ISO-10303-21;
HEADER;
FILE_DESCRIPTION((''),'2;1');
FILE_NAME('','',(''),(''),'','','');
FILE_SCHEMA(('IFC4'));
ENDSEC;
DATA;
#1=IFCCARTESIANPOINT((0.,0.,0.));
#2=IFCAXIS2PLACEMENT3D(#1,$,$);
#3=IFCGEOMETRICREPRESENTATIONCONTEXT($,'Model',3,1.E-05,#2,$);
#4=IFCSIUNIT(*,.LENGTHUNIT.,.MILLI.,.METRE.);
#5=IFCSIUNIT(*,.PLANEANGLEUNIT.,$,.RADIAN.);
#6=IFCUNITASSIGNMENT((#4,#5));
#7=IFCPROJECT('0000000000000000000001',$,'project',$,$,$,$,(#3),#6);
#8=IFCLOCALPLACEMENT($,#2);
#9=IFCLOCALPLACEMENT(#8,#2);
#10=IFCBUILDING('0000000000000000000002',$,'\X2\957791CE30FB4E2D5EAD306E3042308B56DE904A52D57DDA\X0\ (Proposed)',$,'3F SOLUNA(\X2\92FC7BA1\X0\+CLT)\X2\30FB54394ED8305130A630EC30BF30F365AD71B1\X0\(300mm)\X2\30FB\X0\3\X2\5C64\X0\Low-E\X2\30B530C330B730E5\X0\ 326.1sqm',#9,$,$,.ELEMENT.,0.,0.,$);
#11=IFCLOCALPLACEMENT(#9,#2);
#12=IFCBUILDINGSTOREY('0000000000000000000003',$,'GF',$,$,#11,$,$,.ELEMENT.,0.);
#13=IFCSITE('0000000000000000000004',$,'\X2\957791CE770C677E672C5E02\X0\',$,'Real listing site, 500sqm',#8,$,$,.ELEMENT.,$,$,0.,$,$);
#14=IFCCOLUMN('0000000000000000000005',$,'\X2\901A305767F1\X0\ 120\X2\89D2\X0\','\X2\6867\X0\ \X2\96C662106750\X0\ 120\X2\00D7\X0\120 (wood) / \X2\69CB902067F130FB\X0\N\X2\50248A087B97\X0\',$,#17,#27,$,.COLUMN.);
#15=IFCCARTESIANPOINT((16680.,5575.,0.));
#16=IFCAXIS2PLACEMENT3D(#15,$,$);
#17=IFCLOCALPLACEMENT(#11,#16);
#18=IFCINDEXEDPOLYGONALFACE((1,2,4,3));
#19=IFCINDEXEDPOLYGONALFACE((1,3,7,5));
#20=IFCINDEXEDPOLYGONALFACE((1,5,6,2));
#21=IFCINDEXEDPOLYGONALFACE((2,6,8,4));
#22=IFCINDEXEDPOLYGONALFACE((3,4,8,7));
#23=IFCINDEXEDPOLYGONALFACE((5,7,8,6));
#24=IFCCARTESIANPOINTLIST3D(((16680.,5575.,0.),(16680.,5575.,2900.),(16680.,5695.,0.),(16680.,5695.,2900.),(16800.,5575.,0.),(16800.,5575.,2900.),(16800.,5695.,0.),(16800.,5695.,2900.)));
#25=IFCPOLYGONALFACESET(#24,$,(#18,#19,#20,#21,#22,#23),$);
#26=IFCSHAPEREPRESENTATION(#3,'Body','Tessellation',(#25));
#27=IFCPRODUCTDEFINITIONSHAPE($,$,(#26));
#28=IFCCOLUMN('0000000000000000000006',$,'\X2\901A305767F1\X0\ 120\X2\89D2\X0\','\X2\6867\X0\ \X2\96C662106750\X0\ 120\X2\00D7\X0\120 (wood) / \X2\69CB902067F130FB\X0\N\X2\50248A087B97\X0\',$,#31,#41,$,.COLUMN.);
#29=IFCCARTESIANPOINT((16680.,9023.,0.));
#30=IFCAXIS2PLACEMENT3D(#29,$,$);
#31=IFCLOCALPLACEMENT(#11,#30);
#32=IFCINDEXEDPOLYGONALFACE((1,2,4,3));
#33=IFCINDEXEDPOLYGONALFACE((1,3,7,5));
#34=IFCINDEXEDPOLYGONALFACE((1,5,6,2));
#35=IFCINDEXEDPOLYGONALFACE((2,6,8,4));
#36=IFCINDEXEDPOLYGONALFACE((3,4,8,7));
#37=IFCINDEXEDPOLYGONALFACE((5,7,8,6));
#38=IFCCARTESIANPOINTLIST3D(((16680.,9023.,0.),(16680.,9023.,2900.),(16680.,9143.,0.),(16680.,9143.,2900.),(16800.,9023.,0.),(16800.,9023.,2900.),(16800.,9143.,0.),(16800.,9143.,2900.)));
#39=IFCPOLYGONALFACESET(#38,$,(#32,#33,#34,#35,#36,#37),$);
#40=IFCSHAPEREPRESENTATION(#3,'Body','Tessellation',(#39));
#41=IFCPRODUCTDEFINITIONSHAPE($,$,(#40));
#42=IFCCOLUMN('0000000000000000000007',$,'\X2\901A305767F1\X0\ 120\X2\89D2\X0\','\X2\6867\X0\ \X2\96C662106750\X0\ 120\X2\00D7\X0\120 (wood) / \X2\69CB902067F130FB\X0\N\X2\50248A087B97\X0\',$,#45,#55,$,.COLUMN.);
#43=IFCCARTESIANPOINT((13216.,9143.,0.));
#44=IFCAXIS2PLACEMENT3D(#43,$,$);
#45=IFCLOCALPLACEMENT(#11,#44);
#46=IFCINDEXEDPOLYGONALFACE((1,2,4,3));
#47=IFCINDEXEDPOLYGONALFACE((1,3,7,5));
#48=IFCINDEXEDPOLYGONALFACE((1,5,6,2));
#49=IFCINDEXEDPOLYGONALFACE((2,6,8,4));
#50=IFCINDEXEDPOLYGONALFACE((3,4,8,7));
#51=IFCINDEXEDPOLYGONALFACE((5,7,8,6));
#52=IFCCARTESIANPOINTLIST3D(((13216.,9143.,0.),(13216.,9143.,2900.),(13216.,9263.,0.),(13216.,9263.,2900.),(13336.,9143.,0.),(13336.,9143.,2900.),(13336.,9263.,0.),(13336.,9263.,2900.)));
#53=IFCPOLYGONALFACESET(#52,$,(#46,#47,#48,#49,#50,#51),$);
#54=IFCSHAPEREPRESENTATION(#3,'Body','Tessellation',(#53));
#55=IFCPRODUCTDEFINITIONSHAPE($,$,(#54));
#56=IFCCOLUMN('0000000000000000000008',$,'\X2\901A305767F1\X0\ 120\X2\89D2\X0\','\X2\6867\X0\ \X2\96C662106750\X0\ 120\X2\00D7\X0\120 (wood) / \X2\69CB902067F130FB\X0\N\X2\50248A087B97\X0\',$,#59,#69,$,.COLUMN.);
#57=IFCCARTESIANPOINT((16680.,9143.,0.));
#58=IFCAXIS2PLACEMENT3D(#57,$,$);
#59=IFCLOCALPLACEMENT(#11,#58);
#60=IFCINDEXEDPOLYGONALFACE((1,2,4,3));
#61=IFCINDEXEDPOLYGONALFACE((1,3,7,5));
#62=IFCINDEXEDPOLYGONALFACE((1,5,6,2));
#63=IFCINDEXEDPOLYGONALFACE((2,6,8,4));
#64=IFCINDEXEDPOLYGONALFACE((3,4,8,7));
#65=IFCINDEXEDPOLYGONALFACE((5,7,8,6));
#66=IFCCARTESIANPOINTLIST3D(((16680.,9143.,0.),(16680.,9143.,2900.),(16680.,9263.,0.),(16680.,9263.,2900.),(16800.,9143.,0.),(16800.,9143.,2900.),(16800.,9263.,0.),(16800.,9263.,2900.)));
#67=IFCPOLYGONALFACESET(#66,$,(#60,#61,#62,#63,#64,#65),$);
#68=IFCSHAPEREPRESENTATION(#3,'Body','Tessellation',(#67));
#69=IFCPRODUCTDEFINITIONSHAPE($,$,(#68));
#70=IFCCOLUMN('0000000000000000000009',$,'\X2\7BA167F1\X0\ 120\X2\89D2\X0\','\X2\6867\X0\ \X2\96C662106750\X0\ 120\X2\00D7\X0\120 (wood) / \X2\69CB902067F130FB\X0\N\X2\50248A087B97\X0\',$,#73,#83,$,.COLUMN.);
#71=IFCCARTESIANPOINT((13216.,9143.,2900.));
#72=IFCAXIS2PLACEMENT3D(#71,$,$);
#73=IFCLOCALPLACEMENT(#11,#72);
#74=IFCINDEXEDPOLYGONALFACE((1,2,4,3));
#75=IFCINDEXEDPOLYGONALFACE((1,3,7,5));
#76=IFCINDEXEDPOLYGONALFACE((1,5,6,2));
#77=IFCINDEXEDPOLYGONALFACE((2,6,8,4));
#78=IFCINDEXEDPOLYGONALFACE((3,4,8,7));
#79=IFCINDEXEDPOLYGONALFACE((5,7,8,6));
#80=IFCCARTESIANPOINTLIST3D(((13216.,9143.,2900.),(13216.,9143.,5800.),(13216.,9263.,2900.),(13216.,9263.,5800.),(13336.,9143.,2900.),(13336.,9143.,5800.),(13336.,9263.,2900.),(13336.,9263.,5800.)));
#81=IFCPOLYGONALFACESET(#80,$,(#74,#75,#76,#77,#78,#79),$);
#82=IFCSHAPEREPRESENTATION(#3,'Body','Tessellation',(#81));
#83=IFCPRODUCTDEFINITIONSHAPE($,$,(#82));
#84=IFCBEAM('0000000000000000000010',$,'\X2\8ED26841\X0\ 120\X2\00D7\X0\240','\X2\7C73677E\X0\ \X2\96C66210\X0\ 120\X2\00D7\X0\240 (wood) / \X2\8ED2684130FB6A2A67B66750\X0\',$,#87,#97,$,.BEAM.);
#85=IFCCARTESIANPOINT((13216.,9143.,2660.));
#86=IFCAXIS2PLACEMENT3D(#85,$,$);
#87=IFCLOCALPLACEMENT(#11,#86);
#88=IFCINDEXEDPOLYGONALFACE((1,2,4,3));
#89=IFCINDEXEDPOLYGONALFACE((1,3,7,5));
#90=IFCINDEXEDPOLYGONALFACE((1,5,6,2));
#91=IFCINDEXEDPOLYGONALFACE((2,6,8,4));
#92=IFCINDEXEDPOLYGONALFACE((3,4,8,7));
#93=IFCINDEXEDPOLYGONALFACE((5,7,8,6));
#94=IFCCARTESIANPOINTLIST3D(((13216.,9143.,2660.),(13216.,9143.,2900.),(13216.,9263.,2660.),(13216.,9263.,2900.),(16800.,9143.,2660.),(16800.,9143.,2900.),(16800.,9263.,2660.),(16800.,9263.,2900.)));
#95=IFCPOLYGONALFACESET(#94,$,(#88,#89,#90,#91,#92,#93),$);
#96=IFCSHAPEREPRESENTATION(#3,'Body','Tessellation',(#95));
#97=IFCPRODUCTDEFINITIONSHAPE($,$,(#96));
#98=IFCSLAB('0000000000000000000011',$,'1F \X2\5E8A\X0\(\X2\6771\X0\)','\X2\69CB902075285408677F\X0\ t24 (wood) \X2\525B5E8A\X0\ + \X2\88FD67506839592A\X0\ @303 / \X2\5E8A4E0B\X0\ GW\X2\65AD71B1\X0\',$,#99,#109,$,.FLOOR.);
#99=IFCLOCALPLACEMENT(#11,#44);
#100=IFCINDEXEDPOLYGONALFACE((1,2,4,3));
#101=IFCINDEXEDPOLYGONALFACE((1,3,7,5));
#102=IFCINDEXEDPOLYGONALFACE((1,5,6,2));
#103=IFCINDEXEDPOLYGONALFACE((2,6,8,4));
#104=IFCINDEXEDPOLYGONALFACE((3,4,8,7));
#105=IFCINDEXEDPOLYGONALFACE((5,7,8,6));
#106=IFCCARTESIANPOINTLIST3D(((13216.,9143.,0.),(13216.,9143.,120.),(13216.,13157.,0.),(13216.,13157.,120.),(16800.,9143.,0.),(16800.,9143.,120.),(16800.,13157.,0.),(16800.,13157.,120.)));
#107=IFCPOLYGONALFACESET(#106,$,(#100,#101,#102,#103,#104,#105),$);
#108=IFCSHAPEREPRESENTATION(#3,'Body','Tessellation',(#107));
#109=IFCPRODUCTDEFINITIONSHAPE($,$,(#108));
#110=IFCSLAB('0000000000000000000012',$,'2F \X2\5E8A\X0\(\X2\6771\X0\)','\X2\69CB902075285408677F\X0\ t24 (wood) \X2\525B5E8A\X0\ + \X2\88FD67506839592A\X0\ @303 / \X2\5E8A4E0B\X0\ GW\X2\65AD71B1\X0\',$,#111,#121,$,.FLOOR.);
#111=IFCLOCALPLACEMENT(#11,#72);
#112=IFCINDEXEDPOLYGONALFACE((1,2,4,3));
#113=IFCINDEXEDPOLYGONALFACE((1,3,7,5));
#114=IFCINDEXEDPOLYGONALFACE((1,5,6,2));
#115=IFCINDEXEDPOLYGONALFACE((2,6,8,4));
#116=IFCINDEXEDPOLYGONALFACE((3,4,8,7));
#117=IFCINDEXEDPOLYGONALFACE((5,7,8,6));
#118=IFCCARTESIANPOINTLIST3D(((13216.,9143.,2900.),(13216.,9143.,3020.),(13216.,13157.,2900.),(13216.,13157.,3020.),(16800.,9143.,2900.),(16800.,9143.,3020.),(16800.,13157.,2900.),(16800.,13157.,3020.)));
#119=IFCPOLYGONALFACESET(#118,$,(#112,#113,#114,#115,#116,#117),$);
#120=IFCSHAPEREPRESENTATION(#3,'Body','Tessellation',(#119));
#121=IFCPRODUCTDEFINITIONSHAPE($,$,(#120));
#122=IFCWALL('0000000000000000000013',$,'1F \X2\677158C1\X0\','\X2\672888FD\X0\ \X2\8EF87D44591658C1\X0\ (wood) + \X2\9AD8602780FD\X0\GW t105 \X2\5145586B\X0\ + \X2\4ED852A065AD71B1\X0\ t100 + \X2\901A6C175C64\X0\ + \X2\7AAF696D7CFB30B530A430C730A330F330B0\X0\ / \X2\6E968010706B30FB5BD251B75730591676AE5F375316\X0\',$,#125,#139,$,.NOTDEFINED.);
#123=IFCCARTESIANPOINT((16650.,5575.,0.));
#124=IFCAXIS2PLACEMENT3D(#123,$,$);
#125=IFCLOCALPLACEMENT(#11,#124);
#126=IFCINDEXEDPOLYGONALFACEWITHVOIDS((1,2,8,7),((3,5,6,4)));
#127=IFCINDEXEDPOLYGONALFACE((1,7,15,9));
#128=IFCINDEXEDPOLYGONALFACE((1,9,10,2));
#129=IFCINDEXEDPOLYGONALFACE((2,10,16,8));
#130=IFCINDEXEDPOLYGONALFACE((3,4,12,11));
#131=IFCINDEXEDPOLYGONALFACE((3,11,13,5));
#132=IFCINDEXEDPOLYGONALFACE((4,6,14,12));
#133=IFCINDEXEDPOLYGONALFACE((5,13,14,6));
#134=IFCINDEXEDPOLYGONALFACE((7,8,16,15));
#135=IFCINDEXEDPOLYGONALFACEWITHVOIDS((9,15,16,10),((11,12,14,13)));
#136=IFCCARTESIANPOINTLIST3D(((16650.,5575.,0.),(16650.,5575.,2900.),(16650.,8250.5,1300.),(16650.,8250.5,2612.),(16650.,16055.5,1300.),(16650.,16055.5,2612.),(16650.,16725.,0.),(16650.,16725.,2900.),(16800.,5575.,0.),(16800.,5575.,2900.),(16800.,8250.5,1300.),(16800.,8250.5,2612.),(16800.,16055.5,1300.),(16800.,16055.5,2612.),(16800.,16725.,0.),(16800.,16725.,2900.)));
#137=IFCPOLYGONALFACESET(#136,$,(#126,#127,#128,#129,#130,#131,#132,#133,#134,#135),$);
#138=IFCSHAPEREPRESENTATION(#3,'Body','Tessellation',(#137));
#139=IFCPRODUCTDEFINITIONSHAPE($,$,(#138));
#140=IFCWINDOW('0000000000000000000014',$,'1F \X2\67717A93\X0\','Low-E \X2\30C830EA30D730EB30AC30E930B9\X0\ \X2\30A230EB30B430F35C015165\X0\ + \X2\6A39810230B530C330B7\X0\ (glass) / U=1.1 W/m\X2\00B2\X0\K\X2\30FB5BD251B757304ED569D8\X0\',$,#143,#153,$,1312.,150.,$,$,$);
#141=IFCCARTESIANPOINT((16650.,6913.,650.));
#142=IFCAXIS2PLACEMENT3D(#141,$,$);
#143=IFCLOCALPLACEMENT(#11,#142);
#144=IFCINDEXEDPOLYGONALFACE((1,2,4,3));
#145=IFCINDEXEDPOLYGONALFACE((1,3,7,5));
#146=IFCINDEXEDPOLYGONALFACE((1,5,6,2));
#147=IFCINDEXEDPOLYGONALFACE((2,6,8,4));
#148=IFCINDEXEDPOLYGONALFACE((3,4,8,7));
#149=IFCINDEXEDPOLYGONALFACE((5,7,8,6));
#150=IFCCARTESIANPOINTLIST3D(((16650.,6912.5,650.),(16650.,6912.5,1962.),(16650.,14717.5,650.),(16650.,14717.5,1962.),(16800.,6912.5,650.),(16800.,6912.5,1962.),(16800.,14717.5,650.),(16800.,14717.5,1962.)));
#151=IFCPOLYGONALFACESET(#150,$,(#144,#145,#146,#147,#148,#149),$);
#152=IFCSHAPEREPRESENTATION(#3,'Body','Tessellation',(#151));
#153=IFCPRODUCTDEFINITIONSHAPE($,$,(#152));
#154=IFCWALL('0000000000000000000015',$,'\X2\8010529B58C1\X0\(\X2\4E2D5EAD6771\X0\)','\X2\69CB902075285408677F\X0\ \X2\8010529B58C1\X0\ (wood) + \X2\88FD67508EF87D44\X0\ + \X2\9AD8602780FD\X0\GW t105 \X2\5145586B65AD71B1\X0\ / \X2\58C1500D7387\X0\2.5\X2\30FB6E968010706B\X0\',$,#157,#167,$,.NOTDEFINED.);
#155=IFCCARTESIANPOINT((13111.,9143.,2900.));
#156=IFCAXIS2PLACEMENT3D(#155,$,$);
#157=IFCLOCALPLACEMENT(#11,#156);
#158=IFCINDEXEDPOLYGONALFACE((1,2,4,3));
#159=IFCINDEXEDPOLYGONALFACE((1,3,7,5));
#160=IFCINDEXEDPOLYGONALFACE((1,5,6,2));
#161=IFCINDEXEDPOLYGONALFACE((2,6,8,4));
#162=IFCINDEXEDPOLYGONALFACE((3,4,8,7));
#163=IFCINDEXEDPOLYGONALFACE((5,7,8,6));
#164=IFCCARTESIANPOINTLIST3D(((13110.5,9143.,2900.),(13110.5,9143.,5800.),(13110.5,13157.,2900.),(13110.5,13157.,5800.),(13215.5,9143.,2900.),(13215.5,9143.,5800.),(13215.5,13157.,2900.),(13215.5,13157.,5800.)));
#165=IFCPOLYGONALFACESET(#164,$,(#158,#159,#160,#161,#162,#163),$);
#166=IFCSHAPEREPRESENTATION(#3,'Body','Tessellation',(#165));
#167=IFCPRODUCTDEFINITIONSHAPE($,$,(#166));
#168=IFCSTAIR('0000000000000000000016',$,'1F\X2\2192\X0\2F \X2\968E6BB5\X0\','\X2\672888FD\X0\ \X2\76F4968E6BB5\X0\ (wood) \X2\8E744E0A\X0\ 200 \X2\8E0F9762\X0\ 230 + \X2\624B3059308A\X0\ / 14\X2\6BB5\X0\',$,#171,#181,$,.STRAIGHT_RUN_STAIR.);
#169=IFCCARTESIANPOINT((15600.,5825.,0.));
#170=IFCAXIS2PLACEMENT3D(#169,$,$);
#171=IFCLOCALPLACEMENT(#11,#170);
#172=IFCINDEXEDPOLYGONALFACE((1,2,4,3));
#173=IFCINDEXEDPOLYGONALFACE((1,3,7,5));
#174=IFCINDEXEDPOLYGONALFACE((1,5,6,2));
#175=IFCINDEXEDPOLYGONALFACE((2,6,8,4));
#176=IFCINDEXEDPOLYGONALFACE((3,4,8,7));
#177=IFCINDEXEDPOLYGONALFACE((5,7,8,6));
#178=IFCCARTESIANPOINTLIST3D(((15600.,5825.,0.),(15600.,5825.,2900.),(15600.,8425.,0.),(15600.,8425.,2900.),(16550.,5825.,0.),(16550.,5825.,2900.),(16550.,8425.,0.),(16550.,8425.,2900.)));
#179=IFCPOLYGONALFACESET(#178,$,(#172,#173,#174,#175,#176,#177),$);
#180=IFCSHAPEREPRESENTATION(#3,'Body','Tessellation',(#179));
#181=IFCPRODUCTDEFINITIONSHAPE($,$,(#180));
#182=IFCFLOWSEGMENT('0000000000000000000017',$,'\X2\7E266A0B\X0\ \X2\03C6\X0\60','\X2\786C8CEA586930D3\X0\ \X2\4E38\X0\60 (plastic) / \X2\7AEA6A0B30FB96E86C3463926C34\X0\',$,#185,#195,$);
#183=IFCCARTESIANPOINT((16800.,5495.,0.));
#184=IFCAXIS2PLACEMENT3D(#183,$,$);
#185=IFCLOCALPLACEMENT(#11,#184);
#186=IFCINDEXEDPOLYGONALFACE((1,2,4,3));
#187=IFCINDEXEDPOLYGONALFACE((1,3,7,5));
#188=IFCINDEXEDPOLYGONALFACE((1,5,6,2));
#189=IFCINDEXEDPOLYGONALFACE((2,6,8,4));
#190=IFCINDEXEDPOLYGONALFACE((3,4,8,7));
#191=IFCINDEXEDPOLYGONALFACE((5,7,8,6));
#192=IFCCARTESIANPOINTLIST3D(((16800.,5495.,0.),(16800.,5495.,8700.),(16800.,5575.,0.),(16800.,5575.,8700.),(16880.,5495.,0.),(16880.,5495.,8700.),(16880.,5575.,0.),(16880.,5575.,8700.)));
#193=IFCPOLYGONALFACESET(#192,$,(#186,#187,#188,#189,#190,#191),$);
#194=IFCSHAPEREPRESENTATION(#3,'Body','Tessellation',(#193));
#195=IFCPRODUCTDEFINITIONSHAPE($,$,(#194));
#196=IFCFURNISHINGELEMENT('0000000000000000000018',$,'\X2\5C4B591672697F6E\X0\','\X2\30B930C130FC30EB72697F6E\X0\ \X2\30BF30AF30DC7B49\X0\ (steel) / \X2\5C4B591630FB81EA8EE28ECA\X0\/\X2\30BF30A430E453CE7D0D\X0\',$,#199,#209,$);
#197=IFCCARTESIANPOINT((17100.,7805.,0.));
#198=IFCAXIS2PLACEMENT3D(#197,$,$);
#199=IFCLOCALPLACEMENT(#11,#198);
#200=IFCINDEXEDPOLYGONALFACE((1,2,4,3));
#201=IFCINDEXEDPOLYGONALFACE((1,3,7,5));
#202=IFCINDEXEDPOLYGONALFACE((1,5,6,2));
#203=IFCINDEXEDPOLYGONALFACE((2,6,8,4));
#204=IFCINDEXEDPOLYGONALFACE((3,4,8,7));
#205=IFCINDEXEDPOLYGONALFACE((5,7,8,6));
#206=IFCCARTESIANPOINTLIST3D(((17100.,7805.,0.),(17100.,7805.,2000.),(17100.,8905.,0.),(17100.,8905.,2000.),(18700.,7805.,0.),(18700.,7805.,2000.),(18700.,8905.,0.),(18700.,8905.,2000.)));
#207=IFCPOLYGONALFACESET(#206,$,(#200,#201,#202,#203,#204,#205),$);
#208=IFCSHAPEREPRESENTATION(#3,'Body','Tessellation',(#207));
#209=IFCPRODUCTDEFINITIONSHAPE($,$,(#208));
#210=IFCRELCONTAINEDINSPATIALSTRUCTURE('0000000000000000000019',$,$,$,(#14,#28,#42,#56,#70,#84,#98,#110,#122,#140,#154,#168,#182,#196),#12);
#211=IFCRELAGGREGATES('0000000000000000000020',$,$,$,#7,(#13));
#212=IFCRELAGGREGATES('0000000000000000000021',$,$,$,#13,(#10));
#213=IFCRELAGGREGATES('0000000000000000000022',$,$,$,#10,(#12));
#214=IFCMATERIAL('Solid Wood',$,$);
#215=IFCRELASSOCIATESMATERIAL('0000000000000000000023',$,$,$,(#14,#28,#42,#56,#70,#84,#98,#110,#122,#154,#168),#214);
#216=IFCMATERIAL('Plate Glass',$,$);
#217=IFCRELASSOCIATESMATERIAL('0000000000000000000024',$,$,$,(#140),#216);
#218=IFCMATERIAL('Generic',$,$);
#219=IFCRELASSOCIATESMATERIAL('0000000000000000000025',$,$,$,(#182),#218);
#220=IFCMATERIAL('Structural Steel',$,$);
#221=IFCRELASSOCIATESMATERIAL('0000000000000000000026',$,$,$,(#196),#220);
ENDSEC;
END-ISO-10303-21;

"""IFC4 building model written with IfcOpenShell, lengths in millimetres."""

from ifc_helpers import new_model, si_unit, frame, frame_2d, origin, place, context, project, spatial, rectangle, extrude, material, element, fill, save


model = new_model("IFC4")

# Units and contexts
model_context = context("Model", 3, precision=1e-05, world=origin())
ifc_project = project(units=[si_unit("LENGTHUNIT", "METRE", prefix="MILLI"), si_unit("PLANEANGLEUNIT", "RADIAN")], contexts=[model_context])

# Site, building, storey
site_placement = place(None, origin())
site = spatial("IfcSite", under=ifc_project, at=site_placement, Name="長野県松本市", ObjectType="Real listing site, 500sqm", CompositionType="ELEMENT", RefElevation=0.0)
building_placement = place(site_placement, origin())
building = spatial("IfcBuilding", under=site, at=building_placement, Name="長野・中庭のある回遊動線 (Proposed)", ObjectType="3F SOLUNA(鋼管+CLT)・吹付けウレタン断熱(300mm)・3層Low-Eサッシュ 326.1sqm", CompositionType="ELEMENT", ElevationOfRefHeight=0.0, ElevationOfTerrain=0.0)
storey_placement = place(building_placement, origin())
storey = spatial("IfcBuildingStorey", under=building, at=storey_placement, Name="GF", CompositionType="ELEMENT", Elevation=0.0)

# Columns
ifc_material_1 = material(Name="Solid Wood")
column_1_placement = place(storey_placement, frame((16680.0, 5575.0, 0.0)))
element("IfcColumn", 1, at=column_1_placement, inside=storey, material=ifc_material_1, Name="通し柱 120角", Description="桧 集成材 120×120 (wood) / 構造柱・N値計算", PredefinedType="COLUMN", context=model_context, shape_type="SweptSolid", body=[
    extrude(rectangle(XDim=120.0, YDim=120.0, at=frame_2d((60.0, 60.0))), frame((16680.0, 5575.0, 0.0)), (0.0, 0.0, 1.0), 2900.0),
])
column_2_placement = place(storey_placement, frame((16680.0, 9023.0, 0.0)))
element("IfcColumn", 2, at=column_2_placement, inside=storey, material=ifc_material_1, Name="通し柱 120角", Description="桧 集成材 120×120 (wood) / 構造柱・N値計算", PredefinedType="COLUMN", context=model_context, shape_type="SweptSolid", body=[
    extrude(rectangle(XDim=120.0, YDim=120.0, at=frame_2d((60.0, 60.0))), frame((16680.0, 9023.0, 0.0)), (0.0, 0.0, 1.0), 2900.0),
])
column_3_placement = place(storey_placement, frame((13216.0, 9143.0, 0.0)))
element("IfcColumn", 3, at=column_3_placement, inside=storey, material=ifc_material_1, Name="通し柱 120角", Description="桧 集成材 120×120 (wood) / 構造柱・N値計算", PredefinedType="COLUMN", context=model_context, shape_type="SweptSolid", body=[
    extrude(rectangle(XDim=120.0, YDim=120.0, at=frame_2d((60.0, 60.0))), frame((13216.0, 9143.0, 0.0)), (0.0, 0.0, 1.0), 2900.0),
])
column_4_placement = place(storey_placement, frame((16680.0, 9143.0, 0.0)))
element("IfcColumn", 4, at=column_4_placement, inside=storey, material=ifc_material_1, Name="通し柱 120角", Description="桧 集成材 120×120 (wood) / 構造柱・N値計算", PredefinedType="COLUMN", context=model_context, shape_type="SweptSolid", body=[
    extrude(rectangle(XDim=120.0, YDim=120.0, at=frame_2d((60.0, 60.0))), frame((16680.0, 9143.0, 0.0)), (0.0, 0.0, 1.0), 2900.0),
])
column_5_placement = place(storey_placement, frame((13216.0, 9143.0, 2900.0)))
element("IfcColumn", 5, at=column_5_placement, inside=storey, material=ifc_material_1, Name="管柱 120角", Description="桧 集成材 120×120 (wood) / 構造柱・N値計算", PredefinedType="COLUMN", context=model_context, shape_type="SweptSolid", body=[
    extrude(rectangle(XDim=120.0, YDim=120.0, at=frame_2d((60.0, 60.0))), frame((13216.0, 9143.0, 2900.0)), (0.0, 0.0, 1.0), 2900.0),
])

# Beam
beam_1_placement = place(storey_placement, frame((13216.0, 9143.0, 2660.0)))
element("IfcBeam", 6, at=beam_1_placement, inside=storey, material=ifc_material_1, Name="軒桁 120×240", Description="米松 集成 120×240 (wood) / 軒桁・横架材", PredefinedType="BEAM", context=model_context, shape_type="SweptSolid", body=[
    extrude(rectangle(XDim=3584.0, YDim=120.0, at=frame_2d((1792.0, 60.0))), frame((13216.0, 9143.0, 2660.0)), (0.0, 0.0, 1.0), 240.0),
])

# Slabs
slab_1_placement = place(storey_placement, frame((13216.0, 9143.0, 0.0)))
element("IfcSlab", 7, at=slab_1_placement, inside=storey, material=ifc_material_1, Name="1F 床(東)", Description="構造用合板 t24 (wood) 剛床 + 製材根太 @303 / 床下 GW断熱", PredefinedType="FLOOR", context=model_context, shape_type="SweptSolid", body=[
    extrude(rectangle(XDim=3584.0, YDim=4014.0, at=frame_2d((1792.0, 2007.0))), frame((13216.0, 9143.0, 0.0)), (0.0, 0.0, 1.0), 120.0),
])
slab_2_placement = place(storey_placement, frame((13216.0, 9143.0, 2900.0)))
element("IfcSlab", 8, at=slab_2_placement, inside=storey, material=ifc_material_1, Name="2F 床(東)", Description="構造用合板 t24 (wood) 剛床 + 製材根太 @303 / 床下 GW断熱", PredefinedType="FLOOR", context=model_context, shape_type="SweptSolid", body=[
    extrude(rectangle(XDim=3584.0, YDim=4014.0, at=frame_2d((1792.0, 2007.0))), frame((13216.0, 9143.0, 2900.0)), (0.0, 0.0, 1.0), 120.0),
])

# Wall, opening, window
wall_1_placement = place(storey_placement, frame((16650.0, 5575.0, 0.0)))
wall_1 = element("IfcWall", 9, at=wall_1_placement, inside=storey, material=ifc_material_1, Name="1F 東壁", Description="木製 軸組外壁 (wood) + 高性能GW t105 充填 + 付加断熱 t100 + 通気層 + 窯業系サイディング / 準耐火・寒冷地外皮強化", PredefinedType="NOTDEFINED", context=model_context, shape_type="SweptSolid", body=[
    extrude(rectangle(XDim=150.0, YDim=11150.0, at=frame_2d((75.0, 5575.0))), frame((16650.0, 5575.0, 0.0)), (0.0, 0.0, 1.0), 2900.0),
])
opening_placement = place(storey_placement, frame((16650.0, 6913.0, 650.0)))
opening = element("IfcOpeningElement", 10, at=opening_placement, cuts=wall_1, PredefinedType="NOTDEFINED", context=model_context, shape_type="SweptSolid", body=[
    extrude(rectangle(XDim=150.0, YDim=7805.0, at=frame_2d((75.0, 3902.0))), frame((16650.0, 6913.0, 650.0)), (0.0, 0.0, 1.0), 1312.0),
])
ifc_material_2 = material(Name="Plate Glass")
window_placement = place(storey_placement, frame((16650.0, 6913.0, 650.0)))
window = element("IfcWindow", 11, at=window_placement, inside=storey, material=ifc_material_2, Name="1F 東窓", Description="Low-E トリプルガラス アルゴン封入 + 樹脂サッシ (glass) / U=1.1 W/m²K・寒冷地仕様", OverallHeight=1312.0, OverallWidth=150.0, context=model_context, shape_type="SweptSolid", body=[
    extrude(rectangle(XDim=150.0, YDim=7805.0, at=frame_2d((75.0, 3902.0))), frame((16650.0, 6913.0, 650.0)), (0.0, 0.0, 1.0), 1312.0),
])
fill(opening, window)

# Wall
wall_2_placement = place(storey_placement, frame((13111.0, 9143.0, 2900.0)))
element("IfcWall", 12, at=wall_2_placement, inside=storey, material=ifc_material_1, Name="耐力壁(中庭東)", Description="構造用合板 耐力壁 (wood) + 製材軸組 + 高性能GW t105 充填断熱 / 壁倍率2.5・準耐火", PredefinedType="NOTDEFINED", context=model_context, shape_type="SweptSolid", body=[
    extrude(rectangle(XDim=105.0, YDim=4014.0, at=frame_2d((52.0, 2007.0))), frame((13111.0, 9143.0, 2900.0)), (0.0, 0.0, 1.0), 2900.0),
])

# Stair
stair_placement = place(storey_placement, frame((15600.0, 5825.0, 0.0)))
element("IfcStair", 13, at=stair_placement, inside=storey, material=ifc_material_1, Name="1F→2F 階段", Description="木製 直階段 (wood) 蹴上 200 踏面 230 + 手すり / 14段", PredefinedType="STRAIGHT_RUN_STAIR", context=model_context, shape_type="SweptSolid", body=[
    extrude(rectangle(XDim=950.0, YDim=2600.0, at=frame_2d((475.0, 1300.0))), frame((15600.0, 5825.0, 0.0)), (0.0, 0.0, 1.0), 2900.0),
])

# Flow segment
ifc_material_3 = material(Name="Generic")
flow_segment_placement = place(storey_placement, frame((16800.0, 5495.0, 0.0)))
element("IfcFlowSegment", 14, at=flow_segment_placement, inside=storey, material=ifc_material_3, Name="縦樋 φ60", Description="硬質塩ビ 丸60 (plastic) / 竪樋・雨水排水", context=model_context, shape_type="SweptSolid", body=[
    extrude(rectangle(XDim=80.0, YDim=80.0, at=frame_2d((40.0, 40.0))), frame((16800.0, 5495.0, 0.0)), (0.0, 0.0, 1.0), 8700.0),
])

# Furnishing element
ifc_material_4 = material(Name="Structural Steel")
furnishing_placement = place(storey_placement, frame((17100.0, 7805.0, 0.0)))
element("IfcFurnishingElement", 15, at=furnishing_placement, inside=storey, material=ifc_material_4, Name="屋外物置", Description="スチール物置 タクボ等 (steel) / 屋外・自転車/タイヤ収納", context=model_context, shape_type="SweptSolid", body=[
    extrude(rectangle(XDim=1600.0, YDim=1100.0, at=frame_2d((800.0, 550.0))), frame((17100.0, 7805.0, 0.0)), (0.0, 0.0, 1.0), 2000.0),
])

save(model, "model.ifc")
